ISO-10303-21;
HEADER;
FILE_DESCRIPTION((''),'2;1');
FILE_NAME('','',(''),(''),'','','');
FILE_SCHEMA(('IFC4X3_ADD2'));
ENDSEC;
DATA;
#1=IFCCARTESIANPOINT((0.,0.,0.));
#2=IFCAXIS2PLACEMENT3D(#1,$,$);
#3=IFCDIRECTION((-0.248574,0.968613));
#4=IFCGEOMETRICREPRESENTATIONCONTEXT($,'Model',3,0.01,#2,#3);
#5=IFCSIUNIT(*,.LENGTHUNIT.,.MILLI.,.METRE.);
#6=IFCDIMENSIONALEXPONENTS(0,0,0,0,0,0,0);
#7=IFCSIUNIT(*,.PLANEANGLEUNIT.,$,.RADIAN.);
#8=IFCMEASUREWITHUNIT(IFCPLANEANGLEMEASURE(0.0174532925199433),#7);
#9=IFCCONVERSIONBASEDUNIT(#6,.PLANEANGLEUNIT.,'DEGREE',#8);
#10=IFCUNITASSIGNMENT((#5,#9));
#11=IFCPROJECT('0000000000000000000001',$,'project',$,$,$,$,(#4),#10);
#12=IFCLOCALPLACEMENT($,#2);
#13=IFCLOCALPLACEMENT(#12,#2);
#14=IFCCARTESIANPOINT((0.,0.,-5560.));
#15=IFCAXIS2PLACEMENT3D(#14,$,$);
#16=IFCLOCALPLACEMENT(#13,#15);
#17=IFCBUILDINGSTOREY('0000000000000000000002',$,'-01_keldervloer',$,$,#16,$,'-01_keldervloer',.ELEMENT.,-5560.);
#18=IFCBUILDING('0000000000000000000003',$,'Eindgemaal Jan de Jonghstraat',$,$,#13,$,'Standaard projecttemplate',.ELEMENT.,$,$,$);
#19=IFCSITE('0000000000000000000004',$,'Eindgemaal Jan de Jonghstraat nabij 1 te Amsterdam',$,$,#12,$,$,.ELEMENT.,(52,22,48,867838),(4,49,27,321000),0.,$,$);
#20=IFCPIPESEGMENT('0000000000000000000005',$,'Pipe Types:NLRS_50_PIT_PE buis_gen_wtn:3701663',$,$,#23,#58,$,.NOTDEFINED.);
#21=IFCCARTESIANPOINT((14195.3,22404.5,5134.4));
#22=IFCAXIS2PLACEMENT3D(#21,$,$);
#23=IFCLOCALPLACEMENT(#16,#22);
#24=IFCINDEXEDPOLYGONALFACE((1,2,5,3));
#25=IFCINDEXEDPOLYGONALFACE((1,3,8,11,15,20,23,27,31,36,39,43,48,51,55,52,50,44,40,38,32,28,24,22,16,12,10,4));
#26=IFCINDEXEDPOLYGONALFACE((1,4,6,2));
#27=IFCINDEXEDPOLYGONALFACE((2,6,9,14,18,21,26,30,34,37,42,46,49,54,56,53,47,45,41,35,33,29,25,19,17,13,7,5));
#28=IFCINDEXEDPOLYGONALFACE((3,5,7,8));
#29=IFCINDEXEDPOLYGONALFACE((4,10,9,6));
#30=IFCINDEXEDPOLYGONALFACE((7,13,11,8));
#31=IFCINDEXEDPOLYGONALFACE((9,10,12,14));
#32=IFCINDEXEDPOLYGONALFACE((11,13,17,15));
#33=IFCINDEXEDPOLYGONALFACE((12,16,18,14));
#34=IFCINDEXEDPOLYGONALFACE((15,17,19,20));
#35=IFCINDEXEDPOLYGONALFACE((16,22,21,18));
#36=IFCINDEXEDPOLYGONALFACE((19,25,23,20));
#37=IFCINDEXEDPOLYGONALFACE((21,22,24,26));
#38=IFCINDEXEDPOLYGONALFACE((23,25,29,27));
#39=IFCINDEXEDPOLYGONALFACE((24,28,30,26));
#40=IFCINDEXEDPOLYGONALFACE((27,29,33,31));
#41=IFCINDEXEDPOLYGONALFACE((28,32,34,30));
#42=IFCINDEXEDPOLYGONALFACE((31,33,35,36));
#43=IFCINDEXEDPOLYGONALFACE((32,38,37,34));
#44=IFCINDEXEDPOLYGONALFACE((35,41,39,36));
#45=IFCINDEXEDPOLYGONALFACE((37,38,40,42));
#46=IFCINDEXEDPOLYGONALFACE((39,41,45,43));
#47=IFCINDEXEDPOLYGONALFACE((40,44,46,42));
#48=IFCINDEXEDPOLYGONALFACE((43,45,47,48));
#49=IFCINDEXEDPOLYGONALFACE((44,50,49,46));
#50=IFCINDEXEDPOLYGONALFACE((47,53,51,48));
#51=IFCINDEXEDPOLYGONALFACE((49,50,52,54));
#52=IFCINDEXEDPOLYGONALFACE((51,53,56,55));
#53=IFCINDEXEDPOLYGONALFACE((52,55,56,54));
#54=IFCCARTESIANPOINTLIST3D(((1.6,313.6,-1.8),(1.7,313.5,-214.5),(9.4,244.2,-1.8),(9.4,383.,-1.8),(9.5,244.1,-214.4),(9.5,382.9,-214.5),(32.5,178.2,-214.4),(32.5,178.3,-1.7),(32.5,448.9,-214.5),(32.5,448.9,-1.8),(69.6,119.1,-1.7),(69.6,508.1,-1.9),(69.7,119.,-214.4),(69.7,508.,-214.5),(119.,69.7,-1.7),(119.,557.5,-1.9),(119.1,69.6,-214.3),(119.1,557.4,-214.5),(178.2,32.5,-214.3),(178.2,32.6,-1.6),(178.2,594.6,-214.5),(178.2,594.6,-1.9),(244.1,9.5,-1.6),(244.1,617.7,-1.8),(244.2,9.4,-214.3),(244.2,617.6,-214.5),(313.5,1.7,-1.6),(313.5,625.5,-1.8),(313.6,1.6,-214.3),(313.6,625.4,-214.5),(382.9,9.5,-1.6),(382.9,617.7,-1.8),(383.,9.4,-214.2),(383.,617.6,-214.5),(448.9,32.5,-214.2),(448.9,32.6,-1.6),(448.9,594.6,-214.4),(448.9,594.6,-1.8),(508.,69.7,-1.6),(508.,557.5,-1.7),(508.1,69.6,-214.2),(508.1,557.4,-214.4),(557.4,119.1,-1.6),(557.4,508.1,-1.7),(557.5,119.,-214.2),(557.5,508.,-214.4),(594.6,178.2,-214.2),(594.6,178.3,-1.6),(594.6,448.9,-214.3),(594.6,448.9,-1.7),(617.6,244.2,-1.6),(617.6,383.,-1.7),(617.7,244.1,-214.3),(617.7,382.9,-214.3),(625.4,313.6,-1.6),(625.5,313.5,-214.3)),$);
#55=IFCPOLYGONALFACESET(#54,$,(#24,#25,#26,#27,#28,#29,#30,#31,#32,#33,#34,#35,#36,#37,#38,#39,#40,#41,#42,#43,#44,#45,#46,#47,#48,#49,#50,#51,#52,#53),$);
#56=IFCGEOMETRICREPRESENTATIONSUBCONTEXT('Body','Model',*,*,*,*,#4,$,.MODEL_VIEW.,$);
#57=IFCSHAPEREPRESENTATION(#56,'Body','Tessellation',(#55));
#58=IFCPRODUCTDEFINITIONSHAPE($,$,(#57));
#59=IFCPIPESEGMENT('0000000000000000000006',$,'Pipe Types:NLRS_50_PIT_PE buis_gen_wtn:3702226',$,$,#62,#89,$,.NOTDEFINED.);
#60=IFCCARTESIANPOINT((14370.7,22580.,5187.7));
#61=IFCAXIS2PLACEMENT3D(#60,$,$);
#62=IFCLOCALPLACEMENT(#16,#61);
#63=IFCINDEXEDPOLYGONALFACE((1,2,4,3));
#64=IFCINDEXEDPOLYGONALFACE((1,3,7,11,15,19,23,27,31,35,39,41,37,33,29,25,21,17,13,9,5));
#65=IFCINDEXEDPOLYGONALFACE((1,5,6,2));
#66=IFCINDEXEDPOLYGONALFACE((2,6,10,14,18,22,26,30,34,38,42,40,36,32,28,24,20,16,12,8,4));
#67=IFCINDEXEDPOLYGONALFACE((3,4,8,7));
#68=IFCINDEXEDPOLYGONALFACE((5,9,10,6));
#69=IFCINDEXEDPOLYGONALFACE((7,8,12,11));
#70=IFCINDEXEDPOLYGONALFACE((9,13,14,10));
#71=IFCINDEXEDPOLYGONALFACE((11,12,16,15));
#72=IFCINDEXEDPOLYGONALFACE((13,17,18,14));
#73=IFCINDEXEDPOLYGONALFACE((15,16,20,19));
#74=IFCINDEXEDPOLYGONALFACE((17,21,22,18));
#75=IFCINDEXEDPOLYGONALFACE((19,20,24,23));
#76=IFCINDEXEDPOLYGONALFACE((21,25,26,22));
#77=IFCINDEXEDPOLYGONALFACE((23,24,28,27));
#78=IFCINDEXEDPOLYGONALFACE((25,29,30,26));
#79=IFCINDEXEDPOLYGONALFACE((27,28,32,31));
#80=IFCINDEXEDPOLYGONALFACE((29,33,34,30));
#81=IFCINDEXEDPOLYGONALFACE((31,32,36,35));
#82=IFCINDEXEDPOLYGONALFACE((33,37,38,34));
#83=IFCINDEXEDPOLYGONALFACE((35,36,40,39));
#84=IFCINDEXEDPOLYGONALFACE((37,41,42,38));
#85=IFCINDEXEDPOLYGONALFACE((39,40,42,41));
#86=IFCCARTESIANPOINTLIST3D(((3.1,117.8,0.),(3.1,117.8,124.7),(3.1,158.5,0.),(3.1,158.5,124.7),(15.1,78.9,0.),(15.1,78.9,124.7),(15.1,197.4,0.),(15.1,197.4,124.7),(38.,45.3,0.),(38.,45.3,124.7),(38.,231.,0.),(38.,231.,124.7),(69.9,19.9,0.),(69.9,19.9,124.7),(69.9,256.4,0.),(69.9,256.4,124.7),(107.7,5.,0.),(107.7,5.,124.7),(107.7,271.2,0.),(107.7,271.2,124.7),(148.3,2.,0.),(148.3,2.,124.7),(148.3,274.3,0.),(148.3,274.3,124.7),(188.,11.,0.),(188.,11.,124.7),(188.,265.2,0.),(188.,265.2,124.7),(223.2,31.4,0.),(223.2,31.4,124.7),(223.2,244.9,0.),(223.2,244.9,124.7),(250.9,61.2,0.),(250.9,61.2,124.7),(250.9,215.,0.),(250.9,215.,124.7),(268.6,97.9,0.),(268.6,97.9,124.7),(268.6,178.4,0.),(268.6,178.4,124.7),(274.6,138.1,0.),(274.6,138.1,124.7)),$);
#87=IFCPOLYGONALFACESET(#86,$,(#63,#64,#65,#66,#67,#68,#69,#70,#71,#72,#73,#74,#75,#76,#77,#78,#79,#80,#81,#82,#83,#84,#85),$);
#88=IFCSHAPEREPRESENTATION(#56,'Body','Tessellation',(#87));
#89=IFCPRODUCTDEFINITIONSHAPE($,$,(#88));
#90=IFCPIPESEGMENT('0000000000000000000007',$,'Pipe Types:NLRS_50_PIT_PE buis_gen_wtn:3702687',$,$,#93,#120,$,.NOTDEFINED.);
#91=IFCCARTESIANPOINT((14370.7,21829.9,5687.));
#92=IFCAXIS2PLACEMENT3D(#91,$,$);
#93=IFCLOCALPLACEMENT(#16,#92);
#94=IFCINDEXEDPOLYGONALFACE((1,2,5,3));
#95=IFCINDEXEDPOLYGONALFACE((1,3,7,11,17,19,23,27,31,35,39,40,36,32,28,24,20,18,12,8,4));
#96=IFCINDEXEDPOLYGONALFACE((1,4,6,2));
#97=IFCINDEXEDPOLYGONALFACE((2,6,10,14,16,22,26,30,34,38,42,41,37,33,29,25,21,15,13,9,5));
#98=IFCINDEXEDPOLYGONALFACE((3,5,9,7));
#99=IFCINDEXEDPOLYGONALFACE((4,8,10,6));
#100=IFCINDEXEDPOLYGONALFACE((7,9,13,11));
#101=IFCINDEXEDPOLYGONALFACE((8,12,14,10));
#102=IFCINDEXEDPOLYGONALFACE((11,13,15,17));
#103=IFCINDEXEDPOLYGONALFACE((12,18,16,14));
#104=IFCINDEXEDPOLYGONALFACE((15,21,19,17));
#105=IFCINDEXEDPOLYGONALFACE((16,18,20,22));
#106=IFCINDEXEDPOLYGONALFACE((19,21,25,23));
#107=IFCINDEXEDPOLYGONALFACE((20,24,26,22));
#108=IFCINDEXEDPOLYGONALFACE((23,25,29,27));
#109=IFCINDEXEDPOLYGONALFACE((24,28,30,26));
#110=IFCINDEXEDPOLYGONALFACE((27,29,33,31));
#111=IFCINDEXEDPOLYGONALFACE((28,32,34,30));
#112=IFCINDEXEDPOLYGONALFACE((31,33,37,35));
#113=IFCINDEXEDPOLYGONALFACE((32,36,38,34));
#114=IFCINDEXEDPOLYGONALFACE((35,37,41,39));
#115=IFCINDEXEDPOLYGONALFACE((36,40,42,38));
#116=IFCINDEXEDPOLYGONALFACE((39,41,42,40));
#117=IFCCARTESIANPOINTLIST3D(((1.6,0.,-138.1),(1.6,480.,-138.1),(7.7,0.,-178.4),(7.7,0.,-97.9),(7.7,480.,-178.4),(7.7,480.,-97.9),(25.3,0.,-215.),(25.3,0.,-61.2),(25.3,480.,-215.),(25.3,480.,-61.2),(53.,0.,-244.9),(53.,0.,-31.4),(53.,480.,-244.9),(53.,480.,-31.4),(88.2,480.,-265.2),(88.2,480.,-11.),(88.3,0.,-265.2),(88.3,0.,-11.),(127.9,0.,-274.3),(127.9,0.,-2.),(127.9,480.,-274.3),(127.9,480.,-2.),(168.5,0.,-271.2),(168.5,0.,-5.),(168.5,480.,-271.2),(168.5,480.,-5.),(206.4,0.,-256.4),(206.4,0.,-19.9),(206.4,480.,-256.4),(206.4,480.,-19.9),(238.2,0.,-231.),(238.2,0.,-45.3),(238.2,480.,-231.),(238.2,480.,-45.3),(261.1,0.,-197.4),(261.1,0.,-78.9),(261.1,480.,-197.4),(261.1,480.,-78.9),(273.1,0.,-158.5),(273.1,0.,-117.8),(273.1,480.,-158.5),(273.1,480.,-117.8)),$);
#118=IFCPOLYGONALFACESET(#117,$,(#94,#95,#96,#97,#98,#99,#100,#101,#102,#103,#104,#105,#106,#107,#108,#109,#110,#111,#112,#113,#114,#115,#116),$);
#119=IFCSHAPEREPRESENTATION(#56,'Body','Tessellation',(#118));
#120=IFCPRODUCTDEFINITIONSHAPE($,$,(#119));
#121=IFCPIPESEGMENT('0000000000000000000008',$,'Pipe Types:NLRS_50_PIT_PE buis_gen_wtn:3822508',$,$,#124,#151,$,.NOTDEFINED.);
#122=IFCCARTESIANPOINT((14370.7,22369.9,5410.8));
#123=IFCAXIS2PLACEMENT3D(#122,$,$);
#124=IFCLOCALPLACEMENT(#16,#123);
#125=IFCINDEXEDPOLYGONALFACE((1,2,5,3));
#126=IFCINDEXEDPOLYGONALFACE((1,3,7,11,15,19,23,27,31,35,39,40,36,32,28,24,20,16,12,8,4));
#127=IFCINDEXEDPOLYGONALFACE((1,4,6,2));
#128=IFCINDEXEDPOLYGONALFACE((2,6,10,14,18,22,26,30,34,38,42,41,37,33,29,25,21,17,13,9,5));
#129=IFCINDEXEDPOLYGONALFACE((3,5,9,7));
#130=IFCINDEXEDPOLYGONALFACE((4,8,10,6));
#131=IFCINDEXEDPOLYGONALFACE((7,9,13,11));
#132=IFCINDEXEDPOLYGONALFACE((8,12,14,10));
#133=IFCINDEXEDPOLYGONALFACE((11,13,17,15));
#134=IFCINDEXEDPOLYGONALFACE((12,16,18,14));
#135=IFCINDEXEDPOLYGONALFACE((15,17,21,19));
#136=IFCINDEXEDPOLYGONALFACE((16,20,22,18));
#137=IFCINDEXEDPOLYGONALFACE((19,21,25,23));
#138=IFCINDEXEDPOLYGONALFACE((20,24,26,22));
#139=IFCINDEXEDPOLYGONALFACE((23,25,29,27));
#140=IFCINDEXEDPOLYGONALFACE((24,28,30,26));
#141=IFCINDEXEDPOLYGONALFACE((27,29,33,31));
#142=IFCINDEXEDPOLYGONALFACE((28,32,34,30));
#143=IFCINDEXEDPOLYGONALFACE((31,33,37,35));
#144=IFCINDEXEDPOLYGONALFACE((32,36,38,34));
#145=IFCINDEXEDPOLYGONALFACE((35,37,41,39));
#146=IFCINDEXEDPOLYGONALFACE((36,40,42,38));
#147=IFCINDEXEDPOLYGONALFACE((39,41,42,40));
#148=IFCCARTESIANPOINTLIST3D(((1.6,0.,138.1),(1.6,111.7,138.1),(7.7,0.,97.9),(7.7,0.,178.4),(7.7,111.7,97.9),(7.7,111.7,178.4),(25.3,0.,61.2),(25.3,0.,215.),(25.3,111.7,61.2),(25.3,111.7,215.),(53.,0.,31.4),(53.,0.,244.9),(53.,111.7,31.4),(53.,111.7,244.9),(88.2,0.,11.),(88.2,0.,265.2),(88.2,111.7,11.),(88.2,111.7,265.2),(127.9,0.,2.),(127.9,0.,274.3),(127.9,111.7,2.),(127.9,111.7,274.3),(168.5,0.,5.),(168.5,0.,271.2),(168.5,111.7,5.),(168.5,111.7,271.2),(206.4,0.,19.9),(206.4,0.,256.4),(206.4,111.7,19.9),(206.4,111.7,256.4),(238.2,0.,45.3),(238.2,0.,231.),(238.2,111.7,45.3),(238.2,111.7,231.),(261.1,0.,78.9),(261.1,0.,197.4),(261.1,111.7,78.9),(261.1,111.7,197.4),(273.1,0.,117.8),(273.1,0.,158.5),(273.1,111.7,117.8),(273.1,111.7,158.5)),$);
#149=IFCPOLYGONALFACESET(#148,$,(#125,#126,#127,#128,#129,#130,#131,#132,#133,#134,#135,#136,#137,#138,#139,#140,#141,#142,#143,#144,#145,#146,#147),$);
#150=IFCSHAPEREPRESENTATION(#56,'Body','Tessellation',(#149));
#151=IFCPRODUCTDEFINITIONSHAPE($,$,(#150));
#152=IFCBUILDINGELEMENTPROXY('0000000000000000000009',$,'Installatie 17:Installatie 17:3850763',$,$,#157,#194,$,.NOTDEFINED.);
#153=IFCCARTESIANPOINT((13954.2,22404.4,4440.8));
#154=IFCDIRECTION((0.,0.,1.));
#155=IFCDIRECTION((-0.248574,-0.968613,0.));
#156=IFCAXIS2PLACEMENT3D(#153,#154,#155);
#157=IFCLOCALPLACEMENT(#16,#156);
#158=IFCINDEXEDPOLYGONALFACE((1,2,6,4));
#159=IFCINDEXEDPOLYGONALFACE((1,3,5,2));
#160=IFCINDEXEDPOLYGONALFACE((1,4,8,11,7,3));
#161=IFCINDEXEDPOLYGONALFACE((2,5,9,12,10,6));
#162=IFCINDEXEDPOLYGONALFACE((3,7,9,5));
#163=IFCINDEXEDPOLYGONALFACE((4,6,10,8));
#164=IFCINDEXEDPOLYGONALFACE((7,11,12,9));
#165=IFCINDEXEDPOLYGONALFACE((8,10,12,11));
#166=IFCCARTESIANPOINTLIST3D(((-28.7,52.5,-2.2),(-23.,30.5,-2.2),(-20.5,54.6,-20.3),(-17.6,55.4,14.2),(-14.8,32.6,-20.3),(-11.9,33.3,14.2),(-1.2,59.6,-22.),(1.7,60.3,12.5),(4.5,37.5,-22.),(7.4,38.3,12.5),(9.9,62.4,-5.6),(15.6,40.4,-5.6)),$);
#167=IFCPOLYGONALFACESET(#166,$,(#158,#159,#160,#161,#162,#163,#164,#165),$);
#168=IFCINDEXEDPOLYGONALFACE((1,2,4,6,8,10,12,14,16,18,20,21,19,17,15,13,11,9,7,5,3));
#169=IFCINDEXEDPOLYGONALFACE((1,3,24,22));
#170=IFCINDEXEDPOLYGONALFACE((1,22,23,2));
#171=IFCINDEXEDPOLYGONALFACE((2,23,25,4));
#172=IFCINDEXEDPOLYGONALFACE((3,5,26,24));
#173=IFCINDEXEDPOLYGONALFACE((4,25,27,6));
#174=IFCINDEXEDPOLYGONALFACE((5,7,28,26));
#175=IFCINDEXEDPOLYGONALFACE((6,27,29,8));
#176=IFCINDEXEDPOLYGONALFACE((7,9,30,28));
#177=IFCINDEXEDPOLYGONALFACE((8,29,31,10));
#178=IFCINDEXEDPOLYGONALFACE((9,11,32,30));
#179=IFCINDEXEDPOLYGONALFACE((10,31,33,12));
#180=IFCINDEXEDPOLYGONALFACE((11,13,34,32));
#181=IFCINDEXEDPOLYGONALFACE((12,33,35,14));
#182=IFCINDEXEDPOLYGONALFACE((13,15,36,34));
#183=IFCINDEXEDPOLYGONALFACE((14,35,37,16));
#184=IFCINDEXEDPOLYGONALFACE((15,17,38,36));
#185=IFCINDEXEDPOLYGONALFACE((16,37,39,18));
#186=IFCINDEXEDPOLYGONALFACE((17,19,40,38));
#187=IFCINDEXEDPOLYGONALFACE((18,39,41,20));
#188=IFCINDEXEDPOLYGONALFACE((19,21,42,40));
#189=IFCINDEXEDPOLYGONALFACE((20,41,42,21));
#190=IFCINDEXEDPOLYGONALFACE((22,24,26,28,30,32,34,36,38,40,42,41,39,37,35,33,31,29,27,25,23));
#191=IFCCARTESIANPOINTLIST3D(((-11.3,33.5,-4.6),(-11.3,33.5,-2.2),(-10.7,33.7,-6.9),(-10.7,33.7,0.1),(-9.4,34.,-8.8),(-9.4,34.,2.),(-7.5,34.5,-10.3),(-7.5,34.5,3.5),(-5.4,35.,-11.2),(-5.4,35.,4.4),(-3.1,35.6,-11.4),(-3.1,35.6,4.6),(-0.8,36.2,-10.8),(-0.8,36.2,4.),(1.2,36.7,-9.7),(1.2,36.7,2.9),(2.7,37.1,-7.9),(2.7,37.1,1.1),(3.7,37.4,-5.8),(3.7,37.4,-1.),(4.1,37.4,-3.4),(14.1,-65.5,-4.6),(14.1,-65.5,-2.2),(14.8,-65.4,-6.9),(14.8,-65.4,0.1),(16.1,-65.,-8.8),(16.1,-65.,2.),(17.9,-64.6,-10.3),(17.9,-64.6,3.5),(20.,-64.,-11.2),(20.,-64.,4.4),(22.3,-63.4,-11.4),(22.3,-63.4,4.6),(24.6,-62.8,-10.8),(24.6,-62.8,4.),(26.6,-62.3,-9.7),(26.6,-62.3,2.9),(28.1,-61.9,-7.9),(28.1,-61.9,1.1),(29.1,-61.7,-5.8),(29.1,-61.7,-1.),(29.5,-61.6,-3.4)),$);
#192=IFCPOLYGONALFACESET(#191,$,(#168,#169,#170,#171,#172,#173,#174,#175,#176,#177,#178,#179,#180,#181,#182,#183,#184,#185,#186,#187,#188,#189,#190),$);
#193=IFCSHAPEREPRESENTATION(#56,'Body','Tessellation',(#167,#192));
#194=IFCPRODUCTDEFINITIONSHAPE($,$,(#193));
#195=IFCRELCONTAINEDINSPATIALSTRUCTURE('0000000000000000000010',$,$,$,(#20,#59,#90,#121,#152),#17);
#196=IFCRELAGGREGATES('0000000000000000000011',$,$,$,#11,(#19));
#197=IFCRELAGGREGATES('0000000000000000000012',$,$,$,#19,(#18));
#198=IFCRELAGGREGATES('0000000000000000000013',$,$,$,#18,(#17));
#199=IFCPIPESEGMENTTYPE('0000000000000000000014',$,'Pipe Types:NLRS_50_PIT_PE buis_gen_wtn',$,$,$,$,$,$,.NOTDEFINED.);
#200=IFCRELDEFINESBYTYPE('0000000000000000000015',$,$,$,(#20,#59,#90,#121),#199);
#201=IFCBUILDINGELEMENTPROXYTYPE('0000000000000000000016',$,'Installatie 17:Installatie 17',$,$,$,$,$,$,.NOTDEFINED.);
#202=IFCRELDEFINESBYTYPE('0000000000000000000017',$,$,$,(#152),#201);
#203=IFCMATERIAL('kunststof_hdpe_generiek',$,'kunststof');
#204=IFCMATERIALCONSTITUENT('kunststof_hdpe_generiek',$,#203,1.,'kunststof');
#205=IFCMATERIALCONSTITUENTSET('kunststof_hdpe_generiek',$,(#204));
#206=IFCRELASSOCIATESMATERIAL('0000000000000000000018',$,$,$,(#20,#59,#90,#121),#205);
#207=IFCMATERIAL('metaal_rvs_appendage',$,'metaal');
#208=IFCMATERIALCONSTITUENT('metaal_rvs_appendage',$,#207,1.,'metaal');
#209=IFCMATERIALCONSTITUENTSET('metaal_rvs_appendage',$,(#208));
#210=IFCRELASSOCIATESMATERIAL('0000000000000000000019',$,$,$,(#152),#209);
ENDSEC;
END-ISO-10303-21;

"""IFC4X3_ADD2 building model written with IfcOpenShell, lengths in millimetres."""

from ifc_helpers import new_model, entity, si_unit, converted_unit, direction, frame, frame_2d, origin, origin_2d_with_axis, place, context, subcontext, project, spatial, polyline, circle, outline, extrude, source, transform, mapped, material, constituent, constituent_set, type_object, type_shapes, element, save


model = new_model("IFC4X3_ADD2")

# Units and contexts
model_context = context("Model", 3, precision=0.01, world=origin(), true_north=direction((-0.248574, 0.968613)))
body_context = subcontext(model_context, "Body", "Model", "MODEL_VIEW")
ifc_project = project(units=[si_unit("LENGTHUNIT", "METRE", prefix="MILLI"), converted_unit("PLANEANGLEUNIT", "DEGREE", entity("IfcPlaneAngleMeasure", 0.0174532925199433), si_unit("PLANEANGLEUNIT", "RADIAN"), dimensions=[0, 0, 0, 0, 0, 0, 0])], contexts=[model_context])

# Site, building, storey
site_placement = place(None, origin())
site = spatial("IfcSite", under=ifc_project, at=site_placement, Name="Eindgemaal Jan de Jonghstraat nabij 1 te Amsterdam", CompositionType="ELEMENT", RefLatitude=(52, 22, 48, 867838), RefLongitude=(4, 49, 27, 321000), RefElevation=0.0)
building_placement = place(site_placement, origin())
building = spatial("IfcBuilding", under=site, at=building_placement, Name="Eindgemaal Jan de Jonghstraat", LongName="Standaard projecttemplate", CompositionType="ELEMENT")
storey_placement = place(building_placement, frame((0.0, 0.0, -5560.0)))
storey = spatial("IfcBuildingStorey", under=building, at=storey_placement, Name="-01_keldervloer", LongName="-01_keldervloer", CompositionType="ELEMENT", Elevation=-5560.0)

# Pipe segments
ifc_material_1 = material(Name="kunststof_hdpe_generiek", Category="kunststof")
ifc_constituent_1 = constituent(ifc_material_1, Name="kunststof_hdpe_generiek", Category="kunststof", fraction=1.0)
ifc_constituent_set_1 = constituent_set(constituents=[ifc_constituent_1], Name="kunststof_hdpe_generiek")
pipe_segment_type_1 = type_object("IfcPipeSegmentType", Name="Pipe Types:NLRS_50_PIT_PE buis_gen_wtn", PredefinedType="NOTDEFINED")
pipe_segment_1_placement = place(storey_placement, frame((14195.3, 22404.5, 5134.4)))
element("IfcPipeSegment", 1, at=pipe_segment_1_placement, inside=storey, type_object=pipe_segment_type_1, material=ifc_constituent_set_1, Name="Pipe Types:NLRS_50_PIT_PE buis_gen_wtn:3701663", PredefinedType="NOTDEFINED", context=body_context, shape_type="SweptSolid", body=[
    extrude(circle(Radius=311.9, at=frame_2d((0.0, 0.0), x_axis=(1.0, 0.0))), frame((313.6, 313.5, -214.4), z_axis=(-0.000291, 0.000376, 1.0), x_axis=(1.0, 0.0, 0.000291)), (0.0, 0.0, 1.0), 212.7),
])
pipe_segment_2_placement = place(storey_placement, frame((14370.7, 22580.0, 5187.7)))
element("IfcPipeSegment", 2, at=pipe_segment_2_placement, inside=storey, type_object=pipe_segment_type_1, material=ifc_constituent_set_1, Name="Pipe Types:NLRS_50_PIT_PE buis_gen_wtn:3702226", PredefinedType="NOTDEFINED", context=body_context, shape_type="SweptSolid", body=[
    extrude(circle(Radius=136.5, at=origin_2d_with_axis()), frame((138.1, 138.1, 0.0)), (0.0, 0.0, 1.0), 124.7),
])
pipe_segment_3_placement = place(storey_placement, frame((14370.7, 21829.9, 5687.0)))
element("IfcPipeSegment", 3, at=pipe_segment_3_placement, inside=storey, type_object=pipe_segment_type_1, material=ifc_constituent_set_1, Name="Pipe Types:NLRS_50_PIT_PE buis_gen_wtn:3702687", PredefinedType="NOTDEFINED", context=body_context, shape_type="SweptSolid", body=[
    extrude(circle(Radius=136.5, at=frame_2d((0.0, 0.0), x_axis=(1.0, 0.0))), frame((138.1, 480.0, -138.1), z_axis=(0.000034, -1.0, 0.0), x_axis=(-1.0, -0.000034, 0.0)), (0.0, 0.0, 1.0), 480.0),
])
pipe_segment_4_placement = place(storey_placement, frame((14370.7, 22369.9, 5410.8)))
element("IfcPipeSegment", 4, at=pipe_segment_4_placement, inside=storey, type_object=pipe_segment_type_1, material=ifc_constituent_set_1, Name="Pipe Types:NLRS_50_PIT_PE buis_gen_wtn:3822508", PredefinedType="NOTDEFINED", context=body_context, shape_type="SweptSolid", body=[
    extrude(circle(Radius=136.5, at=frame_2d((0.0, 0.0), x_axis=(1.0, 0.0))), frame((138.1, 0.0, 138.1), z_axis=(-0.000034, 1.0, 0.0), x_axis=(-1.0, -0.000034, 0.0)), (0.0, 0.0, 1.0), 111.7),
])

# Building element proxy
ifc_material_2 = material(Name="metaal_rvs_appendage", Category="metaal")
ifc_constituent_2 = constituent(ifc_material_2, Name="metaal_rvs_appendage", Category="metaal", fraction=1.0)
ifc_constituent_set_2 = constituent_set(constituents=[ifc_constituent_2], Name="metaal_rvs_appendage")
building_element_proxy_type_1 = type_object("IfcBuildingElementProxyType", Name="Installatie 17:Installatie 17", PredefinedType="NOTDEFINED")
shared_shape_1 = source(origin(), body_context, "Body", "SweptSolid", [
    extrude(outline(polyline([(-10.0, -17.3), (10.0, -17.3), (20.0, 0.0), (10.0, 17.3), (-10.0, 17.3), (-20.0, 0.0), (-10.0, -17.3)])), frame((-3.7, 35.4, -3.9), z_axis=(-0.248574, 0.968613, 0.0), x_axis=(-0.555573, -0.142576, -0.819152)), (0.0, 0.0, 1.0), 22.8),
    extrude(circle(Radius=8.0, at=frame_2d((0.0, 0.0), x_axis=(1.0, 0.0))), frame((21.7, -63.6, -3.4), z_axis=(-0.248574, 0.968613, 0.0), x_axis=(0.968613, 0.248574, 0.0)), (0.0, 0.0, 1.0), 102.2),
])
type_shapes(building_element_proxy_type_1, [shared_shape_1])
for number, where, z_axis, x_axis, name in (
    (5, (13954.2, 22404.4, 4440.8), (0.0, 0.0, 1.0), (-0.248574, -0.968613, 0.0), "Installatie 17:Installatie 17:3850763"),
):
    element("IfcBuildingElementProxy", number, at=place(storey_placement, frame(where, z_axis=z_axis, x_axis=x_axis)), inside=storey, type_object=building_element_proxy_type_1, material=ifc_constituent_set_2, Name=name, PredefinedType="NOTDEFINED", context=body_context, shape_type="MappedRepresentation", body=[
        mapped(shared_shape_1, transform((0.0, 0.0, 0.0), scale=1.0)),
    ])

save(model, "model.ifc")
